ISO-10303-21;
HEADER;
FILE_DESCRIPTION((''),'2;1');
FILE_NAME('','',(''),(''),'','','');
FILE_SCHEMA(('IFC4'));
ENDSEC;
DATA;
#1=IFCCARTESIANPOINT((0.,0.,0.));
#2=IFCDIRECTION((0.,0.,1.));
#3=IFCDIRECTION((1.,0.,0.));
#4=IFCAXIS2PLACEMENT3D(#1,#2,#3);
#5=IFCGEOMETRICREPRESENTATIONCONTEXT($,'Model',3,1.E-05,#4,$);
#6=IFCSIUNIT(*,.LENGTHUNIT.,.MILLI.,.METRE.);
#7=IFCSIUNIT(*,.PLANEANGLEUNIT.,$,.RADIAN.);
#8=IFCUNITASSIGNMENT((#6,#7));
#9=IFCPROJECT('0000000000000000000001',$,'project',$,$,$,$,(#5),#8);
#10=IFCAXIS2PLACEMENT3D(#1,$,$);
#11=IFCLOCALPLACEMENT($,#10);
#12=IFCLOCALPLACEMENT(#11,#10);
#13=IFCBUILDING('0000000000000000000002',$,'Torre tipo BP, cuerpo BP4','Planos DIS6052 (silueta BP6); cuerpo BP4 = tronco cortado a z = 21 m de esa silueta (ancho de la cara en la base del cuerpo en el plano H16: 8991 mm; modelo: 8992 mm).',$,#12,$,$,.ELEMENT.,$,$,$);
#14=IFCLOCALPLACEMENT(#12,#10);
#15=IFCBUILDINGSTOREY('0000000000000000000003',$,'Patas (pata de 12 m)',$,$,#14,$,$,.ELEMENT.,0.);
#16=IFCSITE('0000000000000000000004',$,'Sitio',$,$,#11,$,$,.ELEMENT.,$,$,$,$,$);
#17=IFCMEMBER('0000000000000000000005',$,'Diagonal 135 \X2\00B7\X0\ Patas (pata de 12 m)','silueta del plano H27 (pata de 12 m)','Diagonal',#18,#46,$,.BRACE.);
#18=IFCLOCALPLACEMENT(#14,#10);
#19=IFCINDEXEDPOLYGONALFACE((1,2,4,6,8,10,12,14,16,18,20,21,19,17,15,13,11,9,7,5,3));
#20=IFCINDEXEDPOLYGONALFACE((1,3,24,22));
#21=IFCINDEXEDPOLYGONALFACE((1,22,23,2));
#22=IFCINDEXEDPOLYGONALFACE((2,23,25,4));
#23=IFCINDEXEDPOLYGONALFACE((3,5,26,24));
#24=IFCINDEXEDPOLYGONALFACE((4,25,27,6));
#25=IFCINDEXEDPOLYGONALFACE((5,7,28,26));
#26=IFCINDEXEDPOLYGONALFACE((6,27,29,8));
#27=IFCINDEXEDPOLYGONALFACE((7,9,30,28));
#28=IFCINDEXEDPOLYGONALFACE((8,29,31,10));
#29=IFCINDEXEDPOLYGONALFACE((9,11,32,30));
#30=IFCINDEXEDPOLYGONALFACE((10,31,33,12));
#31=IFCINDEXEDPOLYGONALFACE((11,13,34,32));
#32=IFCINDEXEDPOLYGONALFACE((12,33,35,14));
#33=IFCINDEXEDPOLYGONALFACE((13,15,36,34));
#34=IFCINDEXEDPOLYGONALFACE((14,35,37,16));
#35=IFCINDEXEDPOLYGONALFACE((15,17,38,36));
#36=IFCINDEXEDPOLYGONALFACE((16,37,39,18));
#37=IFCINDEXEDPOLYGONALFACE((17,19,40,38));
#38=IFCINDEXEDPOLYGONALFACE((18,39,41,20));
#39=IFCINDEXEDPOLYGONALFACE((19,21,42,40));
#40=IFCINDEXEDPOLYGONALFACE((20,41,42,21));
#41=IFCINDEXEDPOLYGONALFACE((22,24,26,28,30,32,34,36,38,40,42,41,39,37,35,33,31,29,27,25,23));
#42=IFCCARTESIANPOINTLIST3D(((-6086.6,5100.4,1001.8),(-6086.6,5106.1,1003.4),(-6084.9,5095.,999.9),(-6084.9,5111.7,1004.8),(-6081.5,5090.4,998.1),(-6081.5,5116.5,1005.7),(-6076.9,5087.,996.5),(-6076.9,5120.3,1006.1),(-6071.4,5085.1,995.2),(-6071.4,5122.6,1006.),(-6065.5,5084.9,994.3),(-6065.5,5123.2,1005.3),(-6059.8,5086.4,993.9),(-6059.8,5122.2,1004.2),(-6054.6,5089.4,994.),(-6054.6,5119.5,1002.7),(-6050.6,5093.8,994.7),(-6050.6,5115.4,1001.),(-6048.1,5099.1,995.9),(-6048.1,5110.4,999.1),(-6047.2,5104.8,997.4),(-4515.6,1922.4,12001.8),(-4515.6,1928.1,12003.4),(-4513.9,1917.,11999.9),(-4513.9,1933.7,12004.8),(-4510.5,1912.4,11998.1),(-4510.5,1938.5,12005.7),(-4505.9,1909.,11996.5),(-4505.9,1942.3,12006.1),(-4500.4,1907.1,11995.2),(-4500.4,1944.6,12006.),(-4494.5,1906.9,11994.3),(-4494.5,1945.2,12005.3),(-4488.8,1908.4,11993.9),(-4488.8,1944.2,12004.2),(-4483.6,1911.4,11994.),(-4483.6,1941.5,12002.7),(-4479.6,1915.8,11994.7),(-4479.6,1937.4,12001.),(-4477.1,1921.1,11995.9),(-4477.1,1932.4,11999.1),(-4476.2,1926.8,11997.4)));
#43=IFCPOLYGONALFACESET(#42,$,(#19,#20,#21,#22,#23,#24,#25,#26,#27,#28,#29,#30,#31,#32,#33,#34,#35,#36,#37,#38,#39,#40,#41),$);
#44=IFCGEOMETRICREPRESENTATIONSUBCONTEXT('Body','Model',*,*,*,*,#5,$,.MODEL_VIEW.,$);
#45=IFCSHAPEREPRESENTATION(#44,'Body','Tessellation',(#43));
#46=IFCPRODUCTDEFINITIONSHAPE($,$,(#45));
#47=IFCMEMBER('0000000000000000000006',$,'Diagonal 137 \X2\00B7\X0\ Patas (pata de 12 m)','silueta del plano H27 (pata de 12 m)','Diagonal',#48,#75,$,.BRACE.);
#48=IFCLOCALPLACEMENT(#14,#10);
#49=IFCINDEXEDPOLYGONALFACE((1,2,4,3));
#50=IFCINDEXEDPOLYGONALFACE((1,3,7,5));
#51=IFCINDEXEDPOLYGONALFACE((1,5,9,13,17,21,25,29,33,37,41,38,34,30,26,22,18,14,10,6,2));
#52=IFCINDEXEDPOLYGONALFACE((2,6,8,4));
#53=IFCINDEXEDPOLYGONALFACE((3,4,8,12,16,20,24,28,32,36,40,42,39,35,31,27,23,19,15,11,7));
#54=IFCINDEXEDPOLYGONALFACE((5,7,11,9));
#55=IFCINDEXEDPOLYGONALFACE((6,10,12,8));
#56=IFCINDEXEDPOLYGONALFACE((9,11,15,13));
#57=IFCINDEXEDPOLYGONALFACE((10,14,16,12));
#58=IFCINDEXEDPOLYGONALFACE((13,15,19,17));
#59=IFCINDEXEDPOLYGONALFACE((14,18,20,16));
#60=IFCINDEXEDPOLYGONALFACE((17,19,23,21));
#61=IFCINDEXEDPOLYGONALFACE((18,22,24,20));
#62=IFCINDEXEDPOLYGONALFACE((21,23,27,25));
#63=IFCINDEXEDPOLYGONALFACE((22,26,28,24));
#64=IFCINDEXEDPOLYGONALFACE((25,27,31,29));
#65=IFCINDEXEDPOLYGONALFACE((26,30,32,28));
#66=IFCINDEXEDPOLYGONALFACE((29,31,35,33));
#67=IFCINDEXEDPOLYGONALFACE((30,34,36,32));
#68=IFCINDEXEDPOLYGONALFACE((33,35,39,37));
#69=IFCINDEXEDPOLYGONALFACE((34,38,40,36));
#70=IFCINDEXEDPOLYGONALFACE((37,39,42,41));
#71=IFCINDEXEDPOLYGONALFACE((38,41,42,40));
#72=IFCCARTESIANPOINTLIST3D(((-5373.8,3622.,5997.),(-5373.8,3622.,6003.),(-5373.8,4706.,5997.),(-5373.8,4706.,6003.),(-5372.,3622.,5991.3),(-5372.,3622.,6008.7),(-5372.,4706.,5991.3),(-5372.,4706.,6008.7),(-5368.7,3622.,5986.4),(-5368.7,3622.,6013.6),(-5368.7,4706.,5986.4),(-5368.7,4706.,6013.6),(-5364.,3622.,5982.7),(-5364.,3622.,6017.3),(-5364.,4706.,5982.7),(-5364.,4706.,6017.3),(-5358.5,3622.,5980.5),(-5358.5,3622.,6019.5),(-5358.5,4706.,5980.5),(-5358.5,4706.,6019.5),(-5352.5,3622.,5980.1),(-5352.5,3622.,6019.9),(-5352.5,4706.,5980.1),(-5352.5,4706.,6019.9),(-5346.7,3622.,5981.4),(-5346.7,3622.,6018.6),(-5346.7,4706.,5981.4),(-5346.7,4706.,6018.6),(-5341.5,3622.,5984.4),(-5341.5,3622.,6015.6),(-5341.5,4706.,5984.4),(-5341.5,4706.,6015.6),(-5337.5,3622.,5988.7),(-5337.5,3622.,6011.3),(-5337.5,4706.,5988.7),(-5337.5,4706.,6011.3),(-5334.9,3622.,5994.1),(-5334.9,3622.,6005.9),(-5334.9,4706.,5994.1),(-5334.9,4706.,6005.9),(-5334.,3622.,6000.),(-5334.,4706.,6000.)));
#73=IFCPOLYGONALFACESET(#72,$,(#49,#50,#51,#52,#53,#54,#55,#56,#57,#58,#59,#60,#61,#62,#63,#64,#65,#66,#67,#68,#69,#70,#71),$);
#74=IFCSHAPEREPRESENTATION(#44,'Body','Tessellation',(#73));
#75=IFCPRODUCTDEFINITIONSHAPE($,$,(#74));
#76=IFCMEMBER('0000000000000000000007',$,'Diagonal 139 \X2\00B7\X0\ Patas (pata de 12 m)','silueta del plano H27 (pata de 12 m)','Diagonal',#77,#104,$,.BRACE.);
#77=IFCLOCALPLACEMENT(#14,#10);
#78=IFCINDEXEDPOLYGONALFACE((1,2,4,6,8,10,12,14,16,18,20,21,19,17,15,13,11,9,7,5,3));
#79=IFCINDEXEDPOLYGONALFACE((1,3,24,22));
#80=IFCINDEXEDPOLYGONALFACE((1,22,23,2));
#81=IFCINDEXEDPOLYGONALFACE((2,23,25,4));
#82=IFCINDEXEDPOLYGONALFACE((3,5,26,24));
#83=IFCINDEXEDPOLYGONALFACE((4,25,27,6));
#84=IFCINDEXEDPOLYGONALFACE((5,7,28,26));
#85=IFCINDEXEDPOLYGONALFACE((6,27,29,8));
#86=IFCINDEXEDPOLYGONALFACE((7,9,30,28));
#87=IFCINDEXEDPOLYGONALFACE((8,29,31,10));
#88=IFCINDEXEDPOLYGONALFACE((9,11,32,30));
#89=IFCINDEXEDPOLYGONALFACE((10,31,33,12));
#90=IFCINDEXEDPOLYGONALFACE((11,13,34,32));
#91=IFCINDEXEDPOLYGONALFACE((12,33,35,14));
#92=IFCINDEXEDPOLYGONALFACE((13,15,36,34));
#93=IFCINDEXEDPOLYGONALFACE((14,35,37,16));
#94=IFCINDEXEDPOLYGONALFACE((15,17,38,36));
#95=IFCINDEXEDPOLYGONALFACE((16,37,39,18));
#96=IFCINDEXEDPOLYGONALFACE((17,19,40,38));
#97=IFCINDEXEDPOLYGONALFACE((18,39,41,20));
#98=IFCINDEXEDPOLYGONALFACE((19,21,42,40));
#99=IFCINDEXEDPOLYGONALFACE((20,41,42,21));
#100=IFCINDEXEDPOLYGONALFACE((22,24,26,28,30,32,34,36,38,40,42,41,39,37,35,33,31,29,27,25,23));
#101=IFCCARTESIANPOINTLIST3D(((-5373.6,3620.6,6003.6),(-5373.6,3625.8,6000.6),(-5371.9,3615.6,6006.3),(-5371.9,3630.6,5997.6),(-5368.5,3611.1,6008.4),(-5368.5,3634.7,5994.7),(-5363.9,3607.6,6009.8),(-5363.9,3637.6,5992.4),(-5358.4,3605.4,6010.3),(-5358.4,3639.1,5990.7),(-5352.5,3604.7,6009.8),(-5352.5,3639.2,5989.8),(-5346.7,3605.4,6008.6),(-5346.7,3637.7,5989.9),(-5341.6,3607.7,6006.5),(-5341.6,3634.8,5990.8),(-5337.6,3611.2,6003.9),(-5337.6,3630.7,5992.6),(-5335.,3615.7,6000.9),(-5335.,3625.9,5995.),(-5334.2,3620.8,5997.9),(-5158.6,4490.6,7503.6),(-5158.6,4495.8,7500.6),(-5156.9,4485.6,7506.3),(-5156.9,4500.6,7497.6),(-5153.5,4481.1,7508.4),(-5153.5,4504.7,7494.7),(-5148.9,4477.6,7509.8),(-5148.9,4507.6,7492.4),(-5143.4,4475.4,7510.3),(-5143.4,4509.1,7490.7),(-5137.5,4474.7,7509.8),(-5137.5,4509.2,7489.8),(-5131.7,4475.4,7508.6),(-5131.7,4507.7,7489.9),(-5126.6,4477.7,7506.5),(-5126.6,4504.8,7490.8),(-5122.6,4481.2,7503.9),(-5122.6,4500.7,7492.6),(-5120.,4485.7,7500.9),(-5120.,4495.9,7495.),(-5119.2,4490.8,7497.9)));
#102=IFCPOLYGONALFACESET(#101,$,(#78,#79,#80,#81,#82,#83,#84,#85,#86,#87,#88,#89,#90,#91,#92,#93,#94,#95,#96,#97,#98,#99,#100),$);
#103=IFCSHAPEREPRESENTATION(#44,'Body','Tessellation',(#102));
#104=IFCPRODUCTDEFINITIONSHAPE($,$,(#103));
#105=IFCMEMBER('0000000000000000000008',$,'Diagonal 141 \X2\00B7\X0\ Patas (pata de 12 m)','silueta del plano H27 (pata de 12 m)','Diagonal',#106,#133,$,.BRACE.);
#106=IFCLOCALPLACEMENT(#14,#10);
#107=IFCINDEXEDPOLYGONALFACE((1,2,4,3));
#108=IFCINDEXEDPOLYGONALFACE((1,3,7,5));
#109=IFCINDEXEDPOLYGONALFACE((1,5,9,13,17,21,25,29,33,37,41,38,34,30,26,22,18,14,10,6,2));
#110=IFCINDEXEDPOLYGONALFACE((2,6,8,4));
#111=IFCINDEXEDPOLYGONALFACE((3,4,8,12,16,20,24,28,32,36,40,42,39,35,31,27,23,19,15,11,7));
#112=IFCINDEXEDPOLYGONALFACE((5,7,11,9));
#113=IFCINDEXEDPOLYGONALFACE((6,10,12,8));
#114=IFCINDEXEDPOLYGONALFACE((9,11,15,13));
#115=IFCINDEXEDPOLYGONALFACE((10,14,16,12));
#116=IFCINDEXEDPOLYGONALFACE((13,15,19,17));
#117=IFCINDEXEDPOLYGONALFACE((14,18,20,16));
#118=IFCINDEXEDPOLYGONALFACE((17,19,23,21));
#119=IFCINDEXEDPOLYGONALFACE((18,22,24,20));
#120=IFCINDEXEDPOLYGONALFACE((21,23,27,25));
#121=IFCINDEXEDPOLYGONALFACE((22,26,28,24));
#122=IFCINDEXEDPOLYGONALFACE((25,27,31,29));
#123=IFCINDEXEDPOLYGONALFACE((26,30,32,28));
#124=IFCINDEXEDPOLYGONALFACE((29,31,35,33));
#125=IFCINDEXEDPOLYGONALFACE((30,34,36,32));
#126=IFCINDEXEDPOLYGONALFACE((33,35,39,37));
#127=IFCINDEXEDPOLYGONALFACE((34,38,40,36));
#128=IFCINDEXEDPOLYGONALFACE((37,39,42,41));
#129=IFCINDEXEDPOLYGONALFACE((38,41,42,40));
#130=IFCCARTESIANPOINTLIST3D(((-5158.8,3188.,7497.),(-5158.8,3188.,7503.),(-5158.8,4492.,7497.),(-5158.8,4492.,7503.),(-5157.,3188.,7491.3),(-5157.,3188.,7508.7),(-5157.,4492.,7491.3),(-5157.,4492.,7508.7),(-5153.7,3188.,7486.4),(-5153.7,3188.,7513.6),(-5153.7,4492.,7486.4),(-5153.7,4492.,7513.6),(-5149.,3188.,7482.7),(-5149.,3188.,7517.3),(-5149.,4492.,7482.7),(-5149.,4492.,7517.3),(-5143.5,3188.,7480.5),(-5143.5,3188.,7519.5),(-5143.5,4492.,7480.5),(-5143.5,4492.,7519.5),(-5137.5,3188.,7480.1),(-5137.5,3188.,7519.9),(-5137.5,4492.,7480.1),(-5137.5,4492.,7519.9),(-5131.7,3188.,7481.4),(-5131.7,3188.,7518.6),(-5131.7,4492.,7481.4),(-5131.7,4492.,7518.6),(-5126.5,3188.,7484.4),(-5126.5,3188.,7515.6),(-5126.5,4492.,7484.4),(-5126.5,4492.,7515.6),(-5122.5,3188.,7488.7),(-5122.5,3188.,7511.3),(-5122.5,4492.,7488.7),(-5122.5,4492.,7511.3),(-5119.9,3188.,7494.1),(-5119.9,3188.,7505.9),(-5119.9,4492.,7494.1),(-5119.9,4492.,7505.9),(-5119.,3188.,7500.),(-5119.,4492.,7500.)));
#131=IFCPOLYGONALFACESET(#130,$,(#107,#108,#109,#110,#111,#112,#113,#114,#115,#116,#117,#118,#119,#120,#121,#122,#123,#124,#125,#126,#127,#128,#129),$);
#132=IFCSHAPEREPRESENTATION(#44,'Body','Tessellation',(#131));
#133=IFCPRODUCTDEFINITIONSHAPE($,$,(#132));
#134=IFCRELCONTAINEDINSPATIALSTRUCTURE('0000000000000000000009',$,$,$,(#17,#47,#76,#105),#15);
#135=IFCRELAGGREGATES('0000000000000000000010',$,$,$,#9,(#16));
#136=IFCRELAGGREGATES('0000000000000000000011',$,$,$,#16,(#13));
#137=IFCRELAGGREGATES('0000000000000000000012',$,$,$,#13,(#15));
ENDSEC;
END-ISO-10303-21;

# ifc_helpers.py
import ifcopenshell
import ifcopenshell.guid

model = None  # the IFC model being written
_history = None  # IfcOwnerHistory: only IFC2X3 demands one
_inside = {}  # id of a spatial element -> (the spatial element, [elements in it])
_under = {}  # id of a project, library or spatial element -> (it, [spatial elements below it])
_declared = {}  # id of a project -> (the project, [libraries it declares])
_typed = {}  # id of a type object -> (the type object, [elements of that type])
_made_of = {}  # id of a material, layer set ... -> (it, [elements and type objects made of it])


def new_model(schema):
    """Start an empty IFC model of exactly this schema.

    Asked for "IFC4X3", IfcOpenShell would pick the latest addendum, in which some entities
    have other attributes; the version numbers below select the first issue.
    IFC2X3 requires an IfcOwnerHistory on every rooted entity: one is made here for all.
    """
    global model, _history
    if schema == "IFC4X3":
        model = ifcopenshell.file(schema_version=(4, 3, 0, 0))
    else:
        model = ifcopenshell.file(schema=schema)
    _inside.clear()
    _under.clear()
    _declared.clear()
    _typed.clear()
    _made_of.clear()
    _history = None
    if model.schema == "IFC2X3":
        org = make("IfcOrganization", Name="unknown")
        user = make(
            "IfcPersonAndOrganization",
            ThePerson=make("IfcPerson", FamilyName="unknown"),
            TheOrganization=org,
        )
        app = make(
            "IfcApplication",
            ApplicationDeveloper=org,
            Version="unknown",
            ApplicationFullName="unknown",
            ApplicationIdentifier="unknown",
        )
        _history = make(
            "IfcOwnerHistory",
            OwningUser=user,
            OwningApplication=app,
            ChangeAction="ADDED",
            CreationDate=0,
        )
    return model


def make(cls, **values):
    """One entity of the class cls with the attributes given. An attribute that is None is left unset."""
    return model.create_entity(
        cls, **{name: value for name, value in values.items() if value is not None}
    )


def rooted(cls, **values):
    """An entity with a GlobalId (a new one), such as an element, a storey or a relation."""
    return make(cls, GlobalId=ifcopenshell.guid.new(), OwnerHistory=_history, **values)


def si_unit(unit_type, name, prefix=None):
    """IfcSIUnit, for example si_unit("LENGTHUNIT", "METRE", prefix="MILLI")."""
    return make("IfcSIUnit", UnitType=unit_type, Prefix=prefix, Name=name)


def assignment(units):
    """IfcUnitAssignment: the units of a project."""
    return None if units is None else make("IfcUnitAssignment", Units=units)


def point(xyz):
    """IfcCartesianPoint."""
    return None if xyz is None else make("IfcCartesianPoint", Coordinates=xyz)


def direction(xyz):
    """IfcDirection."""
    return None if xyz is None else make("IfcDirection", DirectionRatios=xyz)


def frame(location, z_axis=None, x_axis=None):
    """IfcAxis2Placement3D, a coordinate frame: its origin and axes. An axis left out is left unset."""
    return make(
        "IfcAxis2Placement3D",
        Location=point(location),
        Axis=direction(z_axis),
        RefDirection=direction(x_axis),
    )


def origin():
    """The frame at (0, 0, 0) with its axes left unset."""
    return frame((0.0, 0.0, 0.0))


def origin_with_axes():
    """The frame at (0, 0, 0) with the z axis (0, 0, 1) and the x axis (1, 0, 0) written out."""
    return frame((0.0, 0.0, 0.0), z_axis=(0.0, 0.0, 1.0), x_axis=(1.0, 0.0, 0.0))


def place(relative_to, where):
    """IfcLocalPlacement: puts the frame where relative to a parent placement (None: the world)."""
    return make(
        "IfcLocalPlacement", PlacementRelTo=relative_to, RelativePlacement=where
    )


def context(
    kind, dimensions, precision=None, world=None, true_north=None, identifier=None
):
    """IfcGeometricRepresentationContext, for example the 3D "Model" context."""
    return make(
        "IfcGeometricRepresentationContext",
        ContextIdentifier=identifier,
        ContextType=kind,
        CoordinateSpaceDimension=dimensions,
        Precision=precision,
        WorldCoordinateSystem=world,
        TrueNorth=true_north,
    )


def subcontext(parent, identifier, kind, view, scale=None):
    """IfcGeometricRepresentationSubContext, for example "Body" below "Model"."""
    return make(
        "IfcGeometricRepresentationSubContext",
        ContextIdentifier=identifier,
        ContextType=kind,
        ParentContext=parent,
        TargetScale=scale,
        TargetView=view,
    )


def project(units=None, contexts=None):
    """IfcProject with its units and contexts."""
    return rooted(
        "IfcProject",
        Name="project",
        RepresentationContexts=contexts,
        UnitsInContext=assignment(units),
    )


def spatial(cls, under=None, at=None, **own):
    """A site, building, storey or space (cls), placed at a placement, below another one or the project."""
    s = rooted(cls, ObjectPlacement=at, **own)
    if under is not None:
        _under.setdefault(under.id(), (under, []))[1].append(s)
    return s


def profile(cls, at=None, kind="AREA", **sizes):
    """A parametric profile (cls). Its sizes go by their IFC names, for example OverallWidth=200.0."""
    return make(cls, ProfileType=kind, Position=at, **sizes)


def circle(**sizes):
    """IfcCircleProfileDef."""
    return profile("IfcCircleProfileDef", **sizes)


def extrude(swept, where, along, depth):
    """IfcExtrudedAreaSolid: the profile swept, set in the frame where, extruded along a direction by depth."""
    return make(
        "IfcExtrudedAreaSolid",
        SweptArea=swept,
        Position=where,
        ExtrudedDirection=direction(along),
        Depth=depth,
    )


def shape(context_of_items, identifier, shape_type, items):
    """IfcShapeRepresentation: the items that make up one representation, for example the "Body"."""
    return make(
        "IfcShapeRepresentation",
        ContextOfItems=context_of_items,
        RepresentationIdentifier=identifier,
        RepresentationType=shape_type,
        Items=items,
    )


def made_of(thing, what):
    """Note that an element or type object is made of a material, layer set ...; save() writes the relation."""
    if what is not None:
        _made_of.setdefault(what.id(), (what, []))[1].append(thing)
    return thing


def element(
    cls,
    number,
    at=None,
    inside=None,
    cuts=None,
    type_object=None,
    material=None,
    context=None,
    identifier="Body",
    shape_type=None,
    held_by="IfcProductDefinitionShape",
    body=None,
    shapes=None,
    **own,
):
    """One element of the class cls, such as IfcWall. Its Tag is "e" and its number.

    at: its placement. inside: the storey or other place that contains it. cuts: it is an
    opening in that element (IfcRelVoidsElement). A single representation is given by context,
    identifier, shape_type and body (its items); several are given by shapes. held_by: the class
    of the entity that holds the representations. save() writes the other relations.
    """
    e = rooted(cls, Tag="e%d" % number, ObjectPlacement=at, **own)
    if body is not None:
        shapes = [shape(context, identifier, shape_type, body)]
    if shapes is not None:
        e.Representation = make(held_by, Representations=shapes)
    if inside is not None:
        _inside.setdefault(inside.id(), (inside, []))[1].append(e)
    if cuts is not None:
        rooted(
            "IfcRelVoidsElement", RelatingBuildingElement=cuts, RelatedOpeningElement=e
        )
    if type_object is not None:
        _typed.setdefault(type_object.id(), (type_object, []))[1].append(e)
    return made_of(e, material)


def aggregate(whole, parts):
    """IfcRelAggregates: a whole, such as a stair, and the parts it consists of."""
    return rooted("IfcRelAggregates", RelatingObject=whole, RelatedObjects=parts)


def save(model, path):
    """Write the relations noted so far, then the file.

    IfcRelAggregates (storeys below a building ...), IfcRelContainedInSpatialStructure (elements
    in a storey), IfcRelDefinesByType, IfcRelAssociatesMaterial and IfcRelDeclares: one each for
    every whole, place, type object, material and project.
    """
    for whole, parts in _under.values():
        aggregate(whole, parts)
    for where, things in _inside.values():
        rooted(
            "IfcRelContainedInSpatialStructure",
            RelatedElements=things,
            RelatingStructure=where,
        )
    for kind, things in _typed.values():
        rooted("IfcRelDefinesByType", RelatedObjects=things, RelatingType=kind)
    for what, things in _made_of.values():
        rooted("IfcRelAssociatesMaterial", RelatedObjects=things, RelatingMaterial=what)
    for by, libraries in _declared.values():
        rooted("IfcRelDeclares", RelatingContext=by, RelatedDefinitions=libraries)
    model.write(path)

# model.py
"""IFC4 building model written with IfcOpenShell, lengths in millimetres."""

from ifc_helpers import new_model, si_unit, frame, origin, origin_with_axes, place, context, subcontext, project, spatial, circle, extrude, element, save


model = new_model("IFC4")

# Units and contexts
model_context = context("Model", 3, precision=1e-05, world=origin_with_axes())
body_context = subcontext(model_context, "Body", "Model", "MODEL_VIEW")
ifc_project = project(units=[si_unit("LENGTHUNIT", "METRE", prefix="MILLI"), si_unit("PLANEANGLEUNIT", "RADIAN")], contexts=[model_context])

# Site, building, storey
site_placement = place(None, origin())
site = spatial("IfcSite", under=ifc_project, at=site_placement, Name="Sitio", CompositionType="ELEMENT")
building_placement = place(site_placement, origin())
building = spatial("IfcBuilding", under=site, at=building_placement, Name="Torre tipo BP, cuerpo BP4", Description="Planos DIS6052 (silueta BP6); cuerpo BP4 = tronco cortado a z = 21 m de esa silueta (ancho de la cara en la base del cuerpo en el plano H16: 8991 mm; modelo: 8992 mm).", CompositionType="ELEMENT")
storey_placement = place(building_placement, origin())
storey = spatial("IfcBuildingStorey", under=building, at=storey_placement, Name="Patas (pata de 12 m)", CompositionType="ELEMENT", Elevation=0.0)

# Members
member_1_placement = place(storey_placement, frame((-4496.0, 1926.0, 12000.0), z_axis=(-0.135933, 0.274981, -0.951792), x_axis=(0.990718, 0.037729, -0.130592)))
element("IfcMember", 1, at=member_1_placement, inside=storey, Name="Diagonal 135 · Patas (pata de 12 m)", Description="silueta del plano H27 (pata de 12 m)", ObjectType="Diagonal", PredefinedType="BRACE", context=body_context, shape_type="SweptSolid", body=[
    extrude(circle(Radius=20.0), None, (0.0, 0.0, 1.0), 11557.2),
])
member_2_placement = place(storey_placement, frame((-5354.0, 4706.0, 6000.0), z_axis=(0.0, -1.0, 0.0), x_axis=(1.0, 0.0, 0.0)))
element("IfcMember", 2, at=member_2_placement, inside=storey, Name="Diagonal 137 · Patas (pata de 12 m)", Description="silueta del plano H27 (pata de 12 m)", ObjectType="Diagonal", PredefinedType="BRACE", context=body_context, shape_type="SweptSolid", body=[
    extrude(circle(Radius=20.0), None, (0.0, 0.0, 1.0), 1084.0),
])
member_3_placement = place(storey_placement, frame((-5354.0, 3622.0, 6000.0), z_axis=(0.123046, 0.497906, 0.858458), x_axis=(0.992401, -0.061734, -0.106438)))
element("IfcMember", 3, at=member_3_placement, inside=storey, Name="Diagonal 139 · Patas (pata de 12 m)", Description="silueta del plano H27 (pata de 12 m)", ObjectType="Diagonal", PredefinedType="BRACE", context=body_context, shape_type="SweptSolid", body=[
    extrude(circle(Radius=20.0), None, (0.0, 0.0, 1.0), 1747.3),
])
member_4_placement = place(storey_placement, frame((-5139.0, 4492.0, 7500.0), z_axis=(0.0, -1.0, 0.0), x_axis=(1.0, 0.0, 0.0)))
element("IfcMember", 4, at=member_4_placement, inside=storey, Name="Diagonal 141 · Patas (pata de 12 m)", Description="silueta del plano H27 (pata de 12 m)", ObjectType="Diagonal", PredefinedType="BRACE", context=body_context, shape_type="SweptSolid", body=[
    extrude(circle(Radius=20.0), None, (0.0, 0.0, 1.0), 1304.0),
])

save(model, "model.ifc")
